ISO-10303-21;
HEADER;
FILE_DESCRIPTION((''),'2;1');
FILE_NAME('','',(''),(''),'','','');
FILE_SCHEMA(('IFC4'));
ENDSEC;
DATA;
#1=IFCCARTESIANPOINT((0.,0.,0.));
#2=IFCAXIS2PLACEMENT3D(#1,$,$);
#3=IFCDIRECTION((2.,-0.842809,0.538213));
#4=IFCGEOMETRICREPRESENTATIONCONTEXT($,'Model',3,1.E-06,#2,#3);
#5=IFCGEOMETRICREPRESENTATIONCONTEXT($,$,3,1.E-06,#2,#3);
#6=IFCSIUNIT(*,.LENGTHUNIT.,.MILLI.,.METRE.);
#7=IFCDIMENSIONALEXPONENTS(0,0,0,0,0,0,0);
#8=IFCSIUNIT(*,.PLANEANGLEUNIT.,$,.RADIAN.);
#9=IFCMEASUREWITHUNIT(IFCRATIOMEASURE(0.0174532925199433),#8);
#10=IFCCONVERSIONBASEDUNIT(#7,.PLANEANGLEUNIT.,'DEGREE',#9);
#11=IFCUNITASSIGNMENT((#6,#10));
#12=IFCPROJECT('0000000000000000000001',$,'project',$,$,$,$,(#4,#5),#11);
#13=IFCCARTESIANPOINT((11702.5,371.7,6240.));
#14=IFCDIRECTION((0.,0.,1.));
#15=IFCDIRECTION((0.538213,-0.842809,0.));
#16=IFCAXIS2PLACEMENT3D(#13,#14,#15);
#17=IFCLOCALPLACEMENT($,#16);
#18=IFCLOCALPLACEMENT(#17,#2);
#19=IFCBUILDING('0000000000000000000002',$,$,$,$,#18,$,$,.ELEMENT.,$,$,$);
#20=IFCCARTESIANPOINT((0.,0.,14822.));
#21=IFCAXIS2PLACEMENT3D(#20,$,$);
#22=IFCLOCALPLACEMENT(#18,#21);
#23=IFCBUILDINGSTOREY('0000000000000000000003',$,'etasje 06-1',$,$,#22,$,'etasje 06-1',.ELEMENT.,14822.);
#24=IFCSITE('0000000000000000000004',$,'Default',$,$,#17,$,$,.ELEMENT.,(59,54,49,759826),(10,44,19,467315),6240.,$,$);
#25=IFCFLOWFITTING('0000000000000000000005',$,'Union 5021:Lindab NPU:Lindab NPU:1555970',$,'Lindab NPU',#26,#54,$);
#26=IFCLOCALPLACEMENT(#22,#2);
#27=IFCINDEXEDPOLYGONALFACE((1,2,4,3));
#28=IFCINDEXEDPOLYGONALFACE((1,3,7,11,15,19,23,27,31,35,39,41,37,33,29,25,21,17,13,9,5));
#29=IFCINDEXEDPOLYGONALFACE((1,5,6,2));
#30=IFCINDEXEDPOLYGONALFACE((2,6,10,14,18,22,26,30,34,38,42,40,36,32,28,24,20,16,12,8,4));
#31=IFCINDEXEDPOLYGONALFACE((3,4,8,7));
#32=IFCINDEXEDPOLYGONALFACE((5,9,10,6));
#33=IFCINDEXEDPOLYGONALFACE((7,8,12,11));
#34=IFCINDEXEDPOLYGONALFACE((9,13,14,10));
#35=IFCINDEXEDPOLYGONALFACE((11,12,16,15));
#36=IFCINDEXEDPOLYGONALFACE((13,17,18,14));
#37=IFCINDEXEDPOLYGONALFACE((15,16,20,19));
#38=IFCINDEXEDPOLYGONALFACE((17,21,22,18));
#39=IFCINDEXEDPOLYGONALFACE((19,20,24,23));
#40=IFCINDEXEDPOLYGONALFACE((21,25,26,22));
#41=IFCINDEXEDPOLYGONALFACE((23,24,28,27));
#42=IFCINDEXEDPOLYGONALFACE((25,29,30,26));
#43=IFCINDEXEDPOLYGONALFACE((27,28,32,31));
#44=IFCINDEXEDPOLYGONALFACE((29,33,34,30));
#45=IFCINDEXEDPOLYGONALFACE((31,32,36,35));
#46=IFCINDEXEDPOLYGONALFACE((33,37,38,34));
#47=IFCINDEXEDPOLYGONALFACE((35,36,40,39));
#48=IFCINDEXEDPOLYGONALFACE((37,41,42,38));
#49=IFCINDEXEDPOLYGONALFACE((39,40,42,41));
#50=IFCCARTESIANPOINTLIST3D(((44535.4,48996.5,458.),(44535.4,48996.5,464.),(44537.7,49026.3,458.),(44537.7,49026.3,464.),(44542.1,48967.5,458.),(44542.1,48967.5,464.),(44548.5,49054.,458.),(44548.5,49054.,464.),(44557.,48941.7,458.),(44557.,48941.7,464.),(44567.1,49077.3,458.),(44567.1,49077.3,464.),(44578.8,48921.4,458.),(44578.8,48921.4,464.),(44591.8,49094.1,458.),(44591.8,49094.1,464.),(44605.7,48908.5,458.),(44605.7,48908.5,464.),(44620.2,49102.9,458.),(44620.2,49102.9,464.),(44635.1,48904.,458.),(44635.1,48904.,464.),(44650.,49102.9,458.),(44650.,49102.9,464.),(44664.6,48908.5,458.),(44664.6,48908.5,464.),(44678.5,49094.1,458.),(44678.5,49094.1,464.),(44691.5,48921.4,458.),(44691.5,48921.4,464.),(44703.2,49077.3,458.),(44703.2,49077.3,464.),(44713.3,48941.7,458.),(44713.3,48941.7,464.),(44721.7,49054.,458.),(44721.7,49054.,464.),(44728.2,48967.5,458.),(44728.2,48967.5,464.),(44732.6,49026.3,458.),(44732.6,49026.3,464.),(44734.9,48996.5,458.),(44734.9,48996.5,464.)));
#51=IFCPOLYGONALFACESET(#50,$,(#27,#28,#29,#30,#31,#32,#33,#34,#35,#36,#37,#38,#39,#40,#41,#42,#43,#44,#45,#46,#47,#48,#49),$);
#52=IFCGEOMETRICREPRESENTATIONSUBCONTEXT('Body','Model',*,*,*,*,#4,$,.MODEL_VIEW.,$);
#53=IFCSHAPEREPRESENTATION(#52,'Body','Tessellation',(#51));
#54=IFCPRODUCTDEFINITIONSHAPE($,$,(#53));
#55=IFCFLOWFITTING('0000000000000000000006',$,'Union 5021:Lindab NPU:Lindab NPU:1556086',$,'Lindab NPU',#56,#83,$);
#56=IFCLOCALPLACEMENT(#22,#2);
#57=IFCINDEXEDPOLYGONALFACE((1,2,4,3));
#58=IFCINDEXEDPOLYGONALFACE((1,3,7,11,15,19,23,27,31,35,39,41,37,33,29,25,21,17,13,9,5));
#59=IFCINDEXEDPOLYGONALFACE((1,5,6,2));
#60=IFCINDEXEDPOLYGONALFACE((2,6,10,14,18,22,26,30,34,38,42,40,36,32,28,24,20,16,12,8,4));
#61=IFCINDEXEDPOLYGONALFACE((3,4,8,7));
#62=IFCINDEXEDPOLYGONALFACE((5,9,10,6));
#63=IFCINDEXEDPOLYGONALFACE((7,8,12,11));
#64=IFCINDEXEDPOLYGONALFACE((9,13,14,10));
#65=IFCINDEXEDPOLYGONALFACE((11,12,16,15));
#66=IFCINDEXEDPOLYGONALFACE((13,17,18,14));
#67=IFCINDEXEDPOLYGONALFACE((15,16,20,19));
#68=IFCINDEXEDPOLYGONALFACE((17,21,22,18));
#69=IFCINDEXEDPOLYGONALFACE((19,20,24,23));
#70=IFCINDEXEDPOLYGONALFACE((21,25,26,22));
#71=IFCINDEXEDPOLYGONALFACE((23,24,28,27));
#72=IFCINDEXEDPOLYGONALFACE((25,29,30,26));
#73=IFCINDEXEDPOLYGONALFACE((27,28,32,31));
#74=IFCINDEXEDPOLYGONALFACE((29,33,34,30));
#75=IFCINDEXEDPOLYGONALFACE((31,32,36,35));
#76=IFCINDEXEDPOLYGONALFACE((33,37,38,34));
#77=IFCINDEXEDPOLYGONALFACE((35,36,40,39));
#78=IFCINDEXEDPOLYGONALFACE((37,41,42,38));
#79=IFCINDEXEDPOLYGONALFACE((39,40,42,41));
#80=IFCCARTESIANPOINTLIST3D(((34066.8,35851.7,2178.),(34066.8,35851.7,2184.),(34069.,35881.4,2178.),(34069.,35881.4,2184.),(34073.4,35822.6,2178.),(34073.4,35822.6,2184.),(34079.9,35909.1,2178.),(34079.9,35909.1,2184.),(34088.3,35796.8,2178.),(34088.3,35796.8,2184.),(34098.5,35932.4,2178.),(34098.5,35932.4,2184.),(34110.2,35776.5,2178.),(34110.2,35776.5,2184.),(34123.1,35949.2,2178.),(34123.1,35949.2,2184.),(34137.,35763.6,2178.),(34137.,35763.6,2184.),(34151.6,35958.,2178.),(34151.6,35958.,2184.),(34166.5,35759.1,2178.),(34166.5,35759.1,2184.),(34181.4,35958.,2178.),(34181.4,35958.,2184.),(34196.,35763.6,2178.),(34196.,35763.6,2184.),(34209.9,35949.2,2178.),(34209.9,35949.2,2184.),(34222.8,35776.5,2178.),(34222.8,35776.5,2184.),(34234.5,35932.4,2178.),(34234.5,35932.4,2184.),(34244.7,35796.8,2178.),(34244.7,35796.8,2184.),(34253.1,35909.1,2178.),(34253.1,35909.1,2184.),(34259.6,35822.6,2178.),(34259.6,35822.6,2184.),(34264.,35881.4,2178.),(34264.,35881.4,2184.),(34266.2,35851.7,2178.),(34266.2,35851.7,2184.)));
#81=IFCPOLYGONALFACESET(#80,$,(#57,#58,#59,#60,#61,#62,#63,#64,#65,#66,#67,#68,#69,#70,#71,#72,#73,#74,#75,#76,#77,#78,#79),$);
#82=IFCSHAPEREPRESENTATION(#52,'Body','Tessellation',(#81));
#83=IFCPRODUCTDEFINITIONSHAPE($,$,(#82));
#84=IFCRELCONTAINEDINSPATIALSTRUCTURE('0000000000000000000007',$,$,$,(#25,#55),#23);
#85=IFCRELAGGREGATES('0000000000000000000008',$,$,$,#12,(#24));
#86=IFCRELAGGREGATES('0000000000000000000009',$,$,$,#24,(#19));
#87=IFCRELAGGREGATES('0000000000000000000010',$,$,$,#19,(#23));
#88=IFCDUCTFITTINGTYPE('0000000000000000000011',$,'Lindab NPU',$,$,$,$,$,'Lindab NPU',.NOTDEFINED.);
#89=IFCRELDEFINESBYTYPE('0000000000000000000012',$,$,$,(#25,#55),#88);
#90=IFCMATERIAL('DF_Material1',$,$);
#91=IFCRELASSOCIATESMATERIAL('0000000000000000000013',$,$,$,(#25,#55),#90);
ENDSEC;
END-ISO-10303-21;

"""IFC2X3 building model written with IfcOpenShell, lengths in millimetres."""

from ifc_helpers import new_model, entity, si_unit, converted_unit, direction, frame, frame_2d, origin, place, context, subcontext, project, spatial, circle, extrude, source, transform, mapped, material, type_object, type_shapes, element, save


model = new_model("IFC2X3")

# Units and contexts
model_context = context("Model", 3, precision=1e-06, world=origin(), true_north=direction((2.0, -0.842809, 0.538213)))
context_of_model = context(None, 3, precision=1e-06, world=origin(), true_north=direction((2.0, -0.842809, 0.538213)))
body_context = subcontext(model_context, "Body", "Model", "MODEL_VIEW")
ifc_project = project(units=[si_unit("LENGTHUNIT", "METRE", prefix="MILLI"), converted_unit("PLANEANGLEUNIT", "DEGREE", entity("IfcRatioMeasure", 0.0174532925199433), si_unit("PLANEANGLEUNIT", "RADIAN"), dimensions=[0, 0, 0, 0, 0, 0, 0])], contexts=[model_context, context_of_model])

# Site, building, storey
site_placement = place(None, frame((11702.5, 371.7, 6240.0), z_axis=(0.0, 0.0, 1.0), x_axis=(0.538213, -0.842809, 0.0)))
site = spatial("IfcSite", under=ifc_project, at=site_placement, Name="Default", CompositionType="ELEMENT", RefLatitude=(59, 54, 49, 759826), RefLongitude=(10, 44, 19, 467315), RefElevation=6240.0)
building_placement = place(site_placement, origin())
building = spatial("IfcBuilding", under=site, at=building_placement, CompositionType="ELEMENT")
storey_placement = place(building_placement, frame((0.0, 0.0, 14822.0)))
storey = spatial("IfcBuildingStorey", under=building, at=storey_placement, Name="etasje 06-1", LongName="etasje 06-1", CompositionType="ELEMENT", Elevation=14822.0)

# Flow fittings
ifc_material = material(Name="DF_Material1")
duct_fitting_type = type_object("IfcDuctFittingType", Name="Lindab NPU", ElementType="Lindab NPU", PredefinedType="NOTDEFINED")
shared_shape = source(origin(), body_context, "Body", "SweptSolid", [
    extrude(circle(Radius=100.0, at=frame_2d((0.0, 0.0), x_axis=(1.0, 0.0))), frame((0.0, 0.0, 0.0), z_axis=(1.0, 0.0, 0.0), x_axis=(0.0, 1.0, 0.0)), (0.0, 0.0, 1.0), 6.0),
])
type_shapes(duct_fitting_type, [shared_shape])
for number, where, z_axis, x_axis, name in (
    (1, (44635.1, 49004.0, 458.0), (1.0, 0.0, 0.0), (0.0, 0.0, 1.0), "Union 5021:Lindab NPU:Lindab NPU:1555970"),
    (2, (34166.5, 35859.1, 2178.0), (1.0, 0.0, 0.0), (0.0, 0.0, 1.0), "Union 5021:Lindab NPU:Lindab NPU:1556086"),
):
    element("IfcFlowFitting", number, at=place(storey_placement, frame(where, z_axis=z_axis, x_axis=x_axis)), inside=storey, type_object=duct_fitting_type, material=ifc_material, Name=name, ObjectType="Lindab NPU", context=body_context, shape_type="MappedRepresentation", body=[
        mapped(shared_shape, transform((0.0, 0.0, 0.0), scale=1.0)),
    ])

save(model, "model.ifc")
